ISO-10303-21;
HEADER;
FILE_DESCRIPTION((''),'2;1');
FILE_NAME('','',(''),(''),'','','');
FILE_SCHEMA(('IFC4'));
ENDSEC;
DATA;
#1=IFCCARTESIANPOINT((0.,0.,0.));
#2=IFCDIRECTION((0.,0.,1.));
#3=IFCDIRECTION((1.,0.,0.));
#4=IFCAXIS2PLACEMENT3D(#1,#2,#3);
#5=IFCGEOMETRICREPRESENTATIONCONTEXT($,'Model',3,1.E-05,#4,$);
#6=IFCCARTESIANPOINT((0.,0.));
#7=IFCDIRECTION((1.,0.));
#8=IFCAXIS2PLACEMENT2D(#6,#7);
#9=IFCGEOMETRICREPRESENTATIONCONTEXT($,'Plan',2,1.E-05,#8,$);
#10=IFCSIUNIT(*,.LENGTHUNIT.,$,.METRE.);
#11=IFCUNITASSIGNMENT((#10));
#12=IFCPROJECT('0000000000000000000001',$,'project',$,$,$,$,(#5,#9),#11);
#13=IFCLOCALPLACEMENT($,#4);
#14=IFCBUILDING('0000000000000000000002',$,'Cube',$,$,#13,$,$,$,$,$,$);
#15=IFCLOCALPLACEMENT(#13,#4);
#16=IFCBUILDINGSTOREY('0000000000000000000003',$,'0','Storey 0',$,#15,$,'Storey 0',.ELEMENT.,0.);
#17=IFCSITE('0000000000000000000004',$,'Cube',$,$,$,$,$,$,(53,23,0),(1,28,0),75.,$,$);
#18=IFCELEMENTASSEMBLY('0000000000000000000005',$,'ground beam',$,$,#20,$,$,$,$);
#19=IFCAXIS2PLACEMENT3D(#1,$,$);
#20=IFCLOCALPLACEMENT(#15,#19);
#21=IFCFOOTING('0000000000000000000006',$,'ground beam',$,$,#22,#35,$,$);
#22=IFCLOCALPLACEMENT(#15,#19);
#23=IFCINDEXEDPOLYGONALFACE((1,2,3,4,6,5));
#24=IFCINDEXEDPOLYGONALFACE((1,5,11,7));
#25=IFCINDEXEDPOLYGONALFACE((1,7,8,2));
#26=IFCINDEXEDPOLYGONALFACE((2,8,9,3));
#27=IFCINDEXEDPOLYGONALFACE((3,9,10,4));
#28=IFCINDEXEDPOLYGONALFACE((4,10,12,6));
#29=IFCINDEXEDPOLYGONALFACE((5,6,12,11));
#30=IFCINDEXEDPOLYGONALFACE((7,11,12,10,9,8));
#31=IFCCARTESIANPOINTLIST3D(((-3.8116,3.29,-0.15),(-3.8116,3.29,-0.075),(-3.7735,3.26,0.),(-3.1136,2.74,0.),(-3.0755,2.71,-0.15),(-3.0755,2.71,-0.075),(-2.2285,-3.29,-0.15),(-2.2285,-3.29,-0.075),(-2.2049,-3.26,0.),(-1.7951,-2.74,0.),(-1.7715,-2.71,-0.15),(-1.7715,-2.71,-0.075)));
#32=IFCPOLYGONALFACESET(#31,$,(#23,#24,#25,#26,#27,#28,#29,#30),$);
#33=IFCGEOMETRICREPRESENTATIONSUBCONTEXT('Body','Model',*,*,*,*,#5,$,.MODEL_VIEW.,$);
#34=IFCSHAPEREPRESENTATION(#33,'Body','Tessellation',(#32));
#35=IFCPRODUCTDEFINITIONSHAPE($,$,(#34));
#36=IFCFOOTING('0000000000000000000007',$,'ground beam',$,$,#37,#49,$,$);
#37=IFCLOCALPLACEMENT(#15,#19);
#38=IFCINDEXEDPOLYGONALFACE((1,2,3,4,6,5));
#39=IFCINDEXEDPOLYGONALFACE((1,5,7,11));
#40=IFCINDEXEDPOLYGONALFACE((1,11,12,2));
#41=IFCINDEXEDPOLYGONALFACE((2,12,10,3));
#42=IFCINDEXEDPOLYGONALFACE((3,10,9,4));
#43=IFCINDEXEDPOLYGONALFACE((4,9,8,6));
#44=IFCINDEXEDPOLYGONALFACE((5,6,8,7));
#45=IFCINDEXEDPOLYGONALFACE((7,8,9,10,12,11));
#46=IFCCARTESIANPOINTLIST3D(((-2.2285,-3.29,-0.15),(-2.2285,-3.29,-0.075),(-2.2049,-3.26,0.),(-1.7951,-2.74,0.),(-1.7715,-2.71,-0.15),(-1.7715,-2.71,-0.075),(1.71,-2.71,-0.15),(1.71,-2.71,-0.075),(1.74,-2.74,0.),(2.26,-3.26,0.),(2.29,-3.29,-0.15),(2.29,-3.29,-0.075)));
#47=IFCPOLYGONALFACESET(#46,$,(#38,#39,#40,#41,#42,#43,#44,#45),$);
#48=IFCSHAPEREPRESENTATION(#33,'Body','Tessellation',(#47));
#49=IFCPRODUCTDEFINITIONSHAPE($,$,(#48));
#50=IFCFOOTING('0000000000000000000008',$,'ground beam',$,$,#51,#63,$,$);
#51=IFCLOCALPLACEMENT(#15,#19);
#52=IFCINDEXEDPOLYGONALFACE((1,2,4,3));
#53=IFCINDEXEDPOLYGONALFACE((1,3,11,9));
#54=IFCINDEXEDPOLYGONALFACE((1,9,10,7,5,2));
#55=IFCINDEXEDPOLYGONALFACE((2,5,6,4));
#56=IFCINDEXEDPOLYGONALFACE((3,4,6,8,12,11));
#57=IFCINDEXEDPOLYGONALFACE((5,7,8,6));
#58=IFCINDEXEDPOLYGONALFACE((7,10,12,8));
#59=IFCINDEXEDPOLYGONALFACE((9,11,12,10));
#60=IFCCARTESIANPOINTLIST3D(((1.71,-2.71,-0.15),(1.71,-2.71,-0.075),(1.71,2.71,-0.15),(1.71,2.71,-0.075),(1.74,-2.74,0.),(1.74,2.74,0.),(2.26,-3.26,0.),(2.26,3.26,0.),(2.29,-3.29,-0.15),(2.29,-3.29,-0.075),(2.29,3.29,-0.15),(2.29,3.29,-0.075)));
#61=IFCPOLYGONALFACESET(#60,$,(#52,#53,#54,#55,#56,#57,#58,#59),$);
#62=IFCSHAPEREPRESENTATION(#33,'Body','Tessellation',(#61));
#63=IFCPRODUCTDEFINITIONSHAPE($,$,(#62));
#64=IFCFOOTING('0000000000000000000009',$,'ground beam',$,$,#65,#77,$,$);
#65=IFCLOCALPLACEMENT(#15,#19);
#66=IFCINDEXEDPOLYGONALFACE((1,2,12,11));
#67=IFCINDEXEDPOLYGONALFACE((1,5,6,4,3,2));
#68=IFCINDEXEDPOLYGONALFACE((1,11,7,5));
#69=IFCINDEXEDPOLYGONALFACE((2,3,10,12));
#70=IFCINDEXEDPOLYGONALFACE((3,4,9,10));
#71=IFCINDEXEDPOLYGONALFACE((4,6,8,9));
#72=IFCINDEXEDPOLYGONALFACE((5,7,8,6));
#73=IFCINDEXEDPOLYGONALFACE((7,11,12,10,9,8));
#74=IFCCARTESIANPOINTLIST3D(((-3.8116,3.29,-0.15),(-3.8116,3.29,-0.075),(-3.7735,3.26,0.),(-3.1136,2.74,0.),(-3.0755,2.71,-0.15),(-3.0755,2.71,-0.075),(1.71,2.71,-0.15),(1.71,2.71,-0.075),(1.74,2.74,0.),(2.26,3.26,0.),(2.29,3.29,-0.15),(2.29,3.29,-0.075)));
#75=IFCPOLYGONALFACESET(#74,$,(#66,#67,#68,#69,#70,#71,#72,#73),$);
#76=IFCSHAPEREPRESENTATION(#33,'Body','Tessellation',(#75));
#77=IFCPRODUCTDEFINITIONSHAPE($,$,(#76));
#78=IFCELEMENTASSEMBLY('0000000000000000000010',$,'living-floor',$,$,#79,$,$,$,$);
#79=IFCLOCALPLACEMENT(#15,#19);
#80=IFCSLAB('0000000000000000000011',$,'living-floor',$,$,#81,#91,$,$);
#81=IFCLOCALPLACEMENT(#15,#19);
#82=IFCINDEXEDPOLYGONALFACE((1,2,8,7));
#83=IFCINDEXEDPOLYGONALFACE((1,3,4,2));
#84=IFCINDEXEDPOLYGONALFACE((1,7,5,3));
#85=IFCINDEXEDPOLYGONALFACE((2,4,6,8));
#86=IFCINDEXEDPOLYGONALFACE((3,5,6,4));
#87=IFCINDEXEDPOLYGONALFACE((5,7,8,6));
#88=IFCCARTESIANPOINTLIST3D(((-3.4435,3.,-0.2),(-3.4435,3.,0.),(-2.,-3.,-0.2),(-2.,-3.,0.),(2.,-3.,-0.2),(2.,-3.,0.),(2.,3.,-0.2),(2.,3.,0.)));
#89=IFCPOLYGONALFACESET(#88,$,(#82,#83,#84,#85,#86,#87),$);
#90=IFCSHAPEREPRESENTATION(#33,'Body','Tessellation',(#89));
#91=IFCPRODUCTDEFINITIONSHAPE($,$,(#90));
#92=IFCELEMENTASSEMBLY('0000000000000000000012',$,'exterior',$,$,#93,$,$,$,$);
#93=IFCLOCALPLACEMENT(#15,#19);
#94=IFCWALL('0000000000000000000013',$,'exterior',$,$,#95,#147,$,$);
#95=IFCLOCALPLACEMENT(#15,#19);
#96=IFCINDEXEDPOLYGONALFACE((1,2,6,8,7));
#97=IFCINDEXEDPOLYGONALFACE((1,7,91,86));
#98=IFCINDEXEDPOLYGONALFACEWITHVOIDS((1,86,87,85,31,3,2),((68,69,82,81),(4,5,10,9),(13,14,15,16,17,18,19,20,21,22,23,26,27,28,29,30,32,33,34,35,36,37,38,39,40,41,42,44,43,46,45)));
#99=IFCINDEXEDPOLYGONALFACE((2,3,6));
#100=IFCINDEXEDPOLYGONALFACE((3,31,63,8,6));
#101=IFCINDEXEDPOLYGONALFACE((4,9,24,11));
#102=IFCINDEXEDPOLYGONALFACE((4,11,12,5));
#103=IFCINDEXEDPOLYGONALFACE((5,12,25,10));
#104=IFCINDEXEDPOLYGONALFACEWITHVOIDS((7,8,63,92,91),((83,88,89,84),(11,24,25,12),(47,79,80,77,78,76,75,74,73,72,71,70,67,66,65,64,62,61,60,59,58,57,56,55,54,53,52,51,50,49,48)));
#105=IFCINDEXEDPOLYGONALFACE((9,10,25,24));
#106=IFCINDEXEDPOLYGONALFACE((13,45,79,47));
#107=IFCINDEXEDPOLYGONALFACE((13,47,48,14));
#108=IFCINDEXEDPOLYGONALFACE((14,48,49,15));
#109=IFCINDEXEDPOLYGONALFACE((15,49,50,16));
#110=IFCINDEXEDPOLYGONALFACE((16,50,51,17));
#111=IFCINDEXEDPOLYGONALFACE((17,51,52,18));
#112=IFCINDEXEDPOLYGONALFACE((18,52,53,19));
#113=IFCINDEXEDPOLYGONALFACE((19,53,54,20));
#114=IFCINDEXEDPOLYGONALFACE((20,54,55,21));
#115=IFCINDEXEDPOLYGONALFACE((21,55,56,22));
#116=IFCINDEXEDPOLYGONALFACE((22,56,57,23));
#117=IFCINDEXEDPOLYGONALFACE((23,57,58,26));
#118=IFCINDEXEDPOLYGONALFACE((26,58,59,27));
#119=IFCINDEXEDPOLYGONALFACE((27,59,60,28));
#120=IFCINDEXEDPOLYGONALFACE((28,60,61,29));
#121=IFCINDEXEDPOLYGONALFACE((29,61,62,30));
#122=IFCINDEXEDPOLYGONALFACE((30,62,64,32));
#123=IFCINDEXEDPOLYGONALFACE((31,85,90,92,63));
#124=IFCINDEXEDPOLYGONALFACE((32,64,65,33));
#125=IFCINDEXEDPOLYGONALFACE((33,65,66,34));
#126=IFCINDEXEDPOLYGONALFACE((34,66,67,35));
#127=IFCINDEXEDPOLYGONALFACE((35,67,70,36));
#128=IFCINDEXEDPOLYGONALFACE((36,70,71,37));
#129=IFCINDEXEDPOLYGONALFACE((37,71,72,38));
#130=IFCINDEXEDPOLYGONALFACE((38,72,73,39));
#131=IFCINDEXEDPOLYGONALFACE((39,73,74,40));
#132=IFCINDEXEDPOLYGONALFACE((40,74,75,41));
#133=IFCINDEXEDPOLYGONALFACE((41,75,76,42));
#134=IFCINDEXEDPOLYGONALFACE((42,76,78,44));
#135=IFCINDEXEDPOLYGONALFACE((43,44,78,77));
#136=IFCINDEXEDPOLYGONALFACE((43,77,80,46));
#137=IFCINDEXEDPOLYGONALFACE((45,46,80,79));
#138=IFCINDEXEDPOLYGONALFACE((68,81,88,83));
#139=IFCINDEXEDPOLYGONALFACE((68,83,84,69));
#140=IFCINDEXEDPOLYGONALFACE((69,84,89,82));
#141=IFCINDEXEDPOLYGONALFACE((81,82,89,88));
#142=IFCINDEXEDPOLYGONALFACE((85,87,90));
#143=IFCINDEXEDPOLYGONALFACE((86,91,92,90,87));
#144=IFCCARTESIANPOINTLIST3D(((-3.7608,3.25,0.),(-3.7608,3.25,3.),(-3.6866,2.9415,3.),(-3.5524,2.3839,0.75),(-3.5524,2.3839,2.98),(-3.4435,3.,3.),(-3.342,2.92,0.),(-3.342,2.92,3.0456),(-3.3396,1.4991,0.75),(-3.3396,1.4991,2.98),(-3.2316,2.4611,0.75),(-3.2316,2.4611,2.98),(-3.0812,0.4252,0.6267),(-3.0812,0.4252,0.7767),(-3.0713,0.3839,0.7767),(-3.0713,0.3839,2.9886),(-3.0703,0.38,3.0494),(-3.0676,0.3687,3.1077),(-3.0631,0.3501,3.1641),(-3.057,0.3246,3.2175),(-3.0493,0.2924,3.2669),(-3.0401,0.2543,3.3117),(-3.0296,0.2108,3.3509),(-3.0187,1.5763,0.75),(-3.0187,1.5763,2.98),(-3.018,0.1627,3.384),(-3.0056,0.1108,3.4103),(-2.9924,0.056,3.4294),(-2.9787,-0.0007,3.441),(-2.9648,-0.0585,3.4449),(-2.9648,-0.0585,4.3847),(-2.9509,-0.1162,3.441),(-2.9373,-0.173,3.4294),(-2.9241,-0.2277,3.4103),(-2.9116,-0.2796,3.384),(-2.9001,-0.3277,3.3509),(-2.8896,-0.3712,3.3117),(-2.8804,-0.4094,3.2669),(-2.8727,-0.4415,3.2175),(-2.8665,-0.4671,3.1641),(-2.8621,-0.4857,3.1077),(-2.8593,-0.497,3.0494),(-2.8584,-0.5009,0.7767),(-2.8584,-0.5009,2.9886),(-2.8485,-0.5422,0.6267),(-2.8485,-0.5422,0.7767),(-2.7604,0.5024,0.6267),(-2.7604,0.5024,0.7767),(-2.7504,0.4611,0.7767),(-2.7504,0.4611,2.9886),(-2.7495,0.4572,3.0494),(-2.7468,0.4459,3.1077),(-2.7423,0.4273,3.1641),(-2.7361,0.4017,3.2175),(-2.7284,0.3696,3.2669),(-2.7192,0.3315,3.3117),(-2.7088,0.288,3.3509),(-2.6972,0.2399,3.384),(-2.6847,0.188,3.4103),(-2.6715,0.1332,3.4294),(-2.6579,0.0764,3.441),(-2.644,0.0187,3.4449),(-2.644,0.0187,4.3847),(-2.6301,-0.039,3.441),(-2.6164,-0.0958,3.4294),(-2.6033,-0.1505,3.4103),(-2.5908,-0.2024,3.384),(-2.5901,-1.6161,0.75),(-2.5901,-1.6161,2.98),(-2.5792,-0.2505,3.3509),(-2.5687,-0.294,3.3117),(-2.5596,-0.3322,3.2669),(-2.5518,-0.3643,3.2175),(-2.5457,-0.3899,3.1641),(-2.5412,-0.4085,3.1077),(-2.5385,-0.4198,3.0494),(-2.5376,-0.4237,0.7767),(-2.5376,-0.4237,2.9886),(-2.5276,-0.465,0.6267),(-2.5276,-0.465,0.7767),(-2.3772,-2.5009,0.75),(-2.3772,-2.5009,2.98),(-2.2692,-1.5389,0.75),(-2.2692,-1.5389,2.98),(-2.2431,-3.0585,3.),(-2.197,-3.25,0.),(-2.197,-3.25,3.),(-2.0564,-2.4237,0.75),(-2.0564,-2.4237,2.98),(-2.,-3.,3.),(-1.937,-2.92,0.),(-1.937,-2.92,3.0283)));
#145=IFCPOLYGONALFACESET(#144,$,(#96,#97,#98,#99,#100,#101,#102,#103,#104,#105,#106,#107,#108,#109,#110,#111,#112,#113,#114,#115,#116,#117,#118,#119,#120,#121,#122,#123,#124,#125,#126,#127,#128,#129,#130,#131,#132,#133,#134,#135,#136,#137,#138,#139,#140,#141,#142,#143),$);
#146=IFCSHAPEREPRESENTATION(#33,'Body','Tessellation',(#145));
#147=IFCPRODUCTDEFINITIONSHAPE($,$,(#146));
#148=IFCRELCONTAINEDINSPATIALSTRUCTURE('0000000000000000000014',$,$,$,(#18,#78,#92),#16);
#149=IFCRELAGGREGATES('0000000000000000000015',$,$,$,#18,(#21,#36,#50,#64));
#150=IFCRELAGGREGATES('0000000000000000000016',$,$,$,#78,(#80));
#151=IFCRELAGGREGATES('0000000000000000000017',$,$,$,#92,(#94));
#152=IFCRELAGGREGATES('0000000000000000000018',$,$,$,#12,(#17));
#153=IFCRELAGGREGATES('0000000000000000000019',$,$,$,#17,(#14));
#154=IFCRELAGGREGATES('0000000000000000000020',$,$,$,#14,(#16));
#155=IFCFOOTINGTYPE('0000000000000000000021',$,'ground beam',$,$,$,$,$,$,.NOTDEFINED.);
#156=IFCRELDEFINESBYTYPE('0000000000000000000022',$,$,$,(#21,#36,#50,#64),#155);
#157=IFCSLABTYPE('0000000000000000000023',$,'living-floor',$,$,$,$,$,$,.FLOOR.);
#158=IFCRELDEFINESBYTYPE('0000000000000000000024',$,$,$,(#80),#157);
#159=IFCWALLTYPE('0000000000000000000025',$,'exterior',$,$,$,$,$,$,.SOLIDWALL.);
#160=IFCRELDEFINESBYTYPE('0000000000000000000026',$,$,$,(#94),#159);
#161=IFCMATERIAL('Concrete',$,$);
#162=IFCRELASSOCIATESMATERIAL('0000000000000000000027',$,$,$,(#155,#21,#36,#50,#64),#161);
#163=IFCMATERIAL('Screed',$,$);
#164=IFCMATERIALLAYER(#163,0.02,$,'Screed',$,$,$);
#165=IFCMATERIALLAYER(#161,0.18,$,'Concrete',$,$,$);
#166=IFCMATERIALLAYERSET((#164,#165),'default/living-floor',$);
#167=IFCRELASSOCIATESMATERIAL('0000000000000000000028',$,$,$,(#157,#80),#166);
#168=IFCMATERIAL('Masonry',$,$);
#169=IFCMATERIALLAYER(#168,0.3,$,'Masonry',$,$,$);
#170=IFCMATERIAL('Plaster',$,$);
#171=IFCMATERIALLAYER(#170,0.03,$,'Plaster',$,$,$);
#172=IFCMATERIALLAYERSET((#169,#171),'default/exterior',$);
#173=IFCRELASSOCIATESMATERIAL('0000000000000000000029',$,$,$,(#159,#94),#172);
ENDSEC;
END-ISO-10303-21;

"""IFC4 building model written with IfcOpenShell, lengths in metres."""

from ifc_helpers import new_model, si_unit, frame, origin, origin_with_axes, origin_2d_with_axis, place, context, subcontext, project, spatial, polyline, outline, extrude, clip, halfspace, bounded_halfspace, material, layer, layer_set, layer_usage, material_profile, profile_set, profile_usage, type_object, element, aggregate, save


model = new_model("IFC4")

# Units and contexts
model_context = context("Model", 3, precision=1e-05, world=origin_with_axes())
plan_context = context("Plan", 2, precision=1e-05, world=origin_2d_with_axis())
body_context = subcontext(model_context, "Body", "Model", "MODEL_VIEW")
ifc_project = project(units=[si_unit("LENGTHUNIT", "METRE")], contexts=[model_context, plan_context])

# Site, building, storey
site = spatial("IfcSite", under=ifc_project, Name="Cube", RefLatitude=(53, 23, 0), RefLongitude=(1, 28, 0), RefElevation=75.0)
building_placement = place(None, origin_with_axes())
building = spatial("IfcBuilding", under=site, at=building_placement, Name="Cube")
storey_placement = place(building_placement, origin_with_axes())
storey = spatial("IfcBuildingStorey", under=building, at=storey_placement, Name="0", Description="Storey 0", LongName="Storey 0", CompositionType="ELEMENT", Elevation=0.0)

# Element assembly, footings
assembly_1_placement = place(storey_placement, origin_with_axes())
assembly_1 = element("IfcElementAssembly", 1, at=assembly_1_placement, inside=storey, Name="ground beam")
ifc_material_1 = material(Name="Concrete")
ifc_material_profile = material_profile(ifc_material_1, outline(polyline([(-0.26, 0.0), (-0.29, -0.075), (-0.29, -0.15), (0.29, -0.15), (0.29, -0.075), (0.26, 0.0), (-0.26, 0.0)])))
ifc_profile_set = profile_set([ifc_material_profile])
ifc_profile_usage_1 = profile_usage(ifc_profile_set)
footing_type = type_object("IfcFootingType", Name="ground beam", PredefinedType="NOTDEFINED", material=ifc_profile_set)
footing_1_placement = place(assembly_1_placement, frame((-1.7661, -3.9723, 0.0), z_axis=(-0.233915, 0.972257, 0.0), x_axis=(-0.972257, -0.233915, 0.0)))
footing_1 = element("IfcFooting", 2, at=footing_1_placement, type_object=footing_type, material=ifc_profile_usage_1, Name="ground beam", context=body_context, shape_type="Clipping", body=[
    clip(clip(extrude(outline(polyline([(-0.26, 0.0), (-0.29, -0.075), (-0.29, -0.15), (0.29, -0.15), (0.29, -0.075), (0.26, 0.0), (-0.26, 0.0)])), origin_with_axes(), (0.0, 0.0, 1.0), 8.1712), halfspace(frame((0.0, 0.0, 1.0), z_axis=(-0.618904, 0.0, -0.785467), x_axis=(0.0, 1.0, 0.0)), False)), halfspace(frame((0.0, 0.0, 7.1712), z_axis=(-0.785467, 0.0, 0.618904), x_axis=(0.0, 1.0, 0.0)), False)),
])
ifc_profile_usage_2 = profile_usage(ifc_profile_set)
footing_2_placement = place(assembly_1_placement, frame((3.0, -3.0, 0.0), z_axis=(-1.0, 0.0, 0.0), x_axis=(0.0, -1.0, 0.0)))
footing_2 = element("IfcFooting", 3, at=footing_2_placement, type_object=footing_type, material=ifc_profile_usage_2, Name="ground beam", context=body_context, shape_type="Clipping", body=[
    clip(clip(extrude(outline(polyline([(-0.26, 0.0), (-0.29, -0.075), (-0.29, -0.15), (0.29, -0.15), (0.29, -0.075), (0.26, 0.0), (-0.26, 0.0)])), origin_with_axes(), (0.0, 0.0, 1.0), 6.0), halfspace(frame((0.0, 0.0, 1.0), z_axis=(-0.707107, 0.0, -0.707107), x_axis=(0.0, 1.0, 0.0)), False)), halfspace(frame((0.0, 0.0, 5.0), z_axis=(-0.618904, 0.0, 0.785467), x_axis=(0.0, 1.0, 0.0)), False)),
])
ifc_profile_usage_3 = profile_usage(ifc_profile_set)
footing_3_placement = place(assembly_1_placement, frame((2.0, 4.0, 0.0), z_axis=(0.0, -1.0, 0.0), x_axis=(1.0, 0.0, 0.0)))
footing_3 = element("IfcFooting", 4, at=footing_3_placement, type_object=footing_type, material=ifc_profile_usage_3, Name="ground beam", context=body_context, shape_type="Clipping", body=[
    clip(clip(extrude(outline(polyline([(-0.26, 0.0), (-0.29, -0.075), (-0.29, -0.15), (0.29, -0.15), (0.29, -0.075), (0.26, 0.0), (-0.26, 0.0)])), origin_with_axes(), (0.0, 0.0, 1.0), 8.0), halfspace(frame((0.0, 0.0, 1.0), z_axis=(-0.707107, 0.0, -0.707107), x_axis=(0.0, 1.0, 0.0)), False)), halfspace(frame((0.0, 0.0, 7.0), z_axis=(-0.707107, 0.0, 0.707107), x_axis=(0.0, 1.0, 0.0)), False)),
])
ifc_profile_usage_4 = profile_usage(ifc_profile_set)
footing_4_placement = place(assembly_1_placement, frame((-4.4435, 3.0, 0.0), z_axis=(1.0, 0.0, 0.0), x_axis=(0.0, 1.0, 0.0)))
footing_4 = element("IfcFooting", 5, at=footing_4_placement, type_object=footing_type, material=ifc_profile_usage_4, Name="ground beam", context=body_context, shape_type="Clipping", body=[
    clip(clip(extrude(outline(polyline([(-0.26, 0.0), (-0.29, -0.075), (-0.29, -0.15), (0.29, -0.15), (0.29, -0.075), (0.26, 0.0), (-0.26, 0.0)])), origin_with_axes(), (0.0, 0.0, 1.0), 7.4435), halfspace(frame((0.0, 0.0, 1.0), z_axis=(-0.785467, 0.0, -0.618904), x_axis=(0.0, 1.0, 0.0)), False)), halfspace(frame((0.0, 0.0, 6.4435), z_axis=(-0.707107, 0.0, 0.707107), x_axis=(0.0, 1.0, 0.0)), False)),
])
aggregate(assembly_1, [footing_1, footing_2, footing_3, footing_4])

# Element assembly, slab
assembly_2_placement = place(storey_placement, origin_with_axes())
assembly_2 = element("IfcElementAssembly", 6, at=assembly_2_placement, inside=storey, Name="living-floor")
ifc_material_2 = material(Name="Screed")
ifc_layer_1 = layer(ifc_material_2, 0.02, Name="Screed")
ifc_layer_2 = layer(ifc_material_1, 0.18, Name="Concrete")
ifc_layer_set_1 = layer_set([ifc_layer_1, ifc_layer_2], Name="default/living-floor")
ifc_layer_usage_1 = layer_usage(ifc_layer_set_1, "AXIS3", "POSITIVE", 0.0)
slab_type = type_object("IfcSlabType", Name="living-floor", PredefinedType="FLOOR", material=ifc_layer_set_1)
slab_placement = place(assembly_2_placement, frame((2.0, 3.0, -0.2), z_axis=(0.0, 0.0, -1.0), x_axis=(0.0, 1.0, 0.0)))
slab = element("IfcSlab", 7, at=slab_placement, type_object=slab_type, material=ifc_layer_usage_1, Name="living-floor", context=body_context, shape_type="SweptSolid", body=[
    extrude(outline(polyline([(0.0, 0.0), (-6.0, 0.0), (-6.0, -4.0), (0.0, -5.4435), (0.0, 0.0)])), origin(), (0.0, 0.0, -1.0), 0.2),
])
aggregate(assembly_2, [slab])

# Element assembly, wall, openings
assembly_3_placement = place(storey_placement, frame((-3.4435, 3.0, 0.0), z_axis=(0.0, 0.0, 1.0), x_axis=(0.233915, -0.972257, 0.0)))
assembly_3 = element("IfcElementAssembly", 8, at=assembly_3_placement, inside=storey, Name="exterior")
ifc_material_3 = material(Name="Masonry")
ifc_layer_3 = layer(ifc_material_3, 0.3, Name="Masonry")
ifc_material_4 = material(Name="Plaster")
ifc_layer_4 = layer(ifc_material_4, 0.03, Name="Plaster")
ifc_layer_set_2 = layer_set([ifc_layer_3, ifc_layer_4], Name="default/exterior")
ifc_layer_usage_2 = layer_usage(ifc_layer_set_2, "AXIS2", "POSITIVE", -0.25)
wall_type = type_object("IfcWallType", Name="exterior", PredefinedType="SOLIDWALL", material=ifc_layer_set_2)
wall_1_placement = place(assembly_3_placement, frame((0.0, 0.0, 0.0), z_axis=(0.0, 0.0, 1.0), x_axis=(1.0, 0.0, 0.0)))
wall_1 = element("IfcWall", 9, at=wall_1_placement, type_object=wall_type, material=ifc_layer_usage_2, Name="exterior", context=body_context, shape_type="Clipping", body=[
    clip(clip(clip(clip(extrude(outline(polyline([(0.1015, 0.08), (-0.3173, -0.25), (6.3682, -0.25), (6.1082, 0.08), (0.1015, 0.08)])), origin(), (0.0, 0.0, 1.0), 4.385), bounded_halfspace(frame((6.1712, 0.0, 3.0), z_axis=(0.409415, 0.0, 0.912348), x_axis=(0.0, -1.0, 0.0)), False, origin(), polyline([(6.1712, -1.0), (3.0856, -1.0), (3.0856, 1.0), (6.1712, 1.0), (6.1712, -1.0)]))), bounded_halfspace(frame((6.1712, 0.0, 3.0), z_axis=(0.0, 0.0, 1.0), x_axis=(0.0, 1.0, 0.0)), False, origin(), polyline([(6.1712, 1.0), (7.1712, 1.0), (7.1712, -1.0), (6.1712, -1.0), (6.1712, 1.0)]))), bounded_halfspace(frame((3.0856, 0.0, 4.3847), z_axis=(-0.409415, 0.0, 0.912348), x_axis=(0.0, -1.0, 0.0)), False, origin(), polyline([(3.0856, -1.0), (0.0, -1.0), (0.0, 1.0), (3.0856, 1.0), (3.0856, -1.0)]))), bounded_halfspace(frame((0.0, 0.0, 3.0), z_axis=(0.0, 0.0, 1.0), x_axis=(0.0, -1.0, 0.0)), False, origin(), polyline([(0.0, -1.0), (-1.0, -1.0), (-1.0, 1.0), (0.0, 1.0), (0.0, -1.0)]))),
])
opening_1_placement = place(wall_1_placement, frame((0.5735, -0.25, 0.75), z_axis=(0.0, 0.0, 1.0), x_axis=(1.0, 0.0, 0.0)))
element("IfcOpeningElement", 10, at=opening_1_placement, cuts=wall_1, PredefinedType="OPENING", context=body_context, shape_type="SweptSolid", body=[
    extrude(outline(polyline([(0.0, -0.02), (0.91, -0.02), (0.91, 0.35), (0.0, 0.35), (0.0, -0.02)])), origin(), (0.0, 0.0, 1.0), 2.23),
])
opening_2_placement = place(wall_1_placement, frame((2.6306, -0.25, 0.75), z_axis=(0.0, 0.0, 1.0), x_axis=(1.0, 0.0, 0.0)))
element("IfcOpeningElement", 11, at=opening_2_placement, cuts=wall_1, PredefinedType="OPENING", context=body_context, shape_type="SweptSolid", body=[
    extrude(outline(polyline([(0.1333, 2.5617), (0.1781, 2.6009), (0.2275, 2.634), (0.2809, 2.6603), (0.3373, 2.6794), (0.3956, 2.691), (0.455, 2.6949), (0.5144, 2.691), (0.5727, 2.6794), (0.6291, 2.6603), (0.6825, 2.634), (0.7319, 2.6009), (0.7767, 2.5617), (0.8159, 2.5169), (0.849, 2.4675), (0.8753, 2.4141), (0.8944, 2.3577), (0.906, 2.2994), (0.91, 2.2386), (0.91, 2.2069), (0.91, 0.0267), (0.9525, 0.0267), (0.9525, -0.1233), (-0.0425, -0.1233), (-0.0425, 0.0267), (0.0, 0.0267), (0.0, 2.2069), (0.0, 2.2386), (0.004, 2.2994), (0.0156, 2.3577), (0.0347, 2.4141), (0.061, 2.4675), (0.0941, 2.5169), (0.1333, 2.5617)])), frame((0.0, -0.02, 0.0), z_axis=(0.0, -1.0, 0.0), x_axis=(1.0, 0.0, 0.0)), (0.0, 0.0, -1.0), 0.37),
])
opening_3_placement = place(wall_1_placement, frame((4.6877, -0.25, 0.75), z_axis=(0.0, 0.0, 1.0), x_axis=(1.0, 0.0, 0.0)))
element("IfcOpeningElement", 12, at=opening_3_placement, cuts=wall_1, PredefinedType="OPENING", context=body_context, shape_type="SweptSolid", body=[
    extrude(outline(polyline([(0.0, -0.02), (0.91, -0.02), (0.91, 0.35), (0.0, 0.35), (0.0, -0.02)])), origin(), (0.0, 0.0, 1.0), 2.23),
])
aggregate(assembly_3, [wall_1])

save(model, "model.ifc")
